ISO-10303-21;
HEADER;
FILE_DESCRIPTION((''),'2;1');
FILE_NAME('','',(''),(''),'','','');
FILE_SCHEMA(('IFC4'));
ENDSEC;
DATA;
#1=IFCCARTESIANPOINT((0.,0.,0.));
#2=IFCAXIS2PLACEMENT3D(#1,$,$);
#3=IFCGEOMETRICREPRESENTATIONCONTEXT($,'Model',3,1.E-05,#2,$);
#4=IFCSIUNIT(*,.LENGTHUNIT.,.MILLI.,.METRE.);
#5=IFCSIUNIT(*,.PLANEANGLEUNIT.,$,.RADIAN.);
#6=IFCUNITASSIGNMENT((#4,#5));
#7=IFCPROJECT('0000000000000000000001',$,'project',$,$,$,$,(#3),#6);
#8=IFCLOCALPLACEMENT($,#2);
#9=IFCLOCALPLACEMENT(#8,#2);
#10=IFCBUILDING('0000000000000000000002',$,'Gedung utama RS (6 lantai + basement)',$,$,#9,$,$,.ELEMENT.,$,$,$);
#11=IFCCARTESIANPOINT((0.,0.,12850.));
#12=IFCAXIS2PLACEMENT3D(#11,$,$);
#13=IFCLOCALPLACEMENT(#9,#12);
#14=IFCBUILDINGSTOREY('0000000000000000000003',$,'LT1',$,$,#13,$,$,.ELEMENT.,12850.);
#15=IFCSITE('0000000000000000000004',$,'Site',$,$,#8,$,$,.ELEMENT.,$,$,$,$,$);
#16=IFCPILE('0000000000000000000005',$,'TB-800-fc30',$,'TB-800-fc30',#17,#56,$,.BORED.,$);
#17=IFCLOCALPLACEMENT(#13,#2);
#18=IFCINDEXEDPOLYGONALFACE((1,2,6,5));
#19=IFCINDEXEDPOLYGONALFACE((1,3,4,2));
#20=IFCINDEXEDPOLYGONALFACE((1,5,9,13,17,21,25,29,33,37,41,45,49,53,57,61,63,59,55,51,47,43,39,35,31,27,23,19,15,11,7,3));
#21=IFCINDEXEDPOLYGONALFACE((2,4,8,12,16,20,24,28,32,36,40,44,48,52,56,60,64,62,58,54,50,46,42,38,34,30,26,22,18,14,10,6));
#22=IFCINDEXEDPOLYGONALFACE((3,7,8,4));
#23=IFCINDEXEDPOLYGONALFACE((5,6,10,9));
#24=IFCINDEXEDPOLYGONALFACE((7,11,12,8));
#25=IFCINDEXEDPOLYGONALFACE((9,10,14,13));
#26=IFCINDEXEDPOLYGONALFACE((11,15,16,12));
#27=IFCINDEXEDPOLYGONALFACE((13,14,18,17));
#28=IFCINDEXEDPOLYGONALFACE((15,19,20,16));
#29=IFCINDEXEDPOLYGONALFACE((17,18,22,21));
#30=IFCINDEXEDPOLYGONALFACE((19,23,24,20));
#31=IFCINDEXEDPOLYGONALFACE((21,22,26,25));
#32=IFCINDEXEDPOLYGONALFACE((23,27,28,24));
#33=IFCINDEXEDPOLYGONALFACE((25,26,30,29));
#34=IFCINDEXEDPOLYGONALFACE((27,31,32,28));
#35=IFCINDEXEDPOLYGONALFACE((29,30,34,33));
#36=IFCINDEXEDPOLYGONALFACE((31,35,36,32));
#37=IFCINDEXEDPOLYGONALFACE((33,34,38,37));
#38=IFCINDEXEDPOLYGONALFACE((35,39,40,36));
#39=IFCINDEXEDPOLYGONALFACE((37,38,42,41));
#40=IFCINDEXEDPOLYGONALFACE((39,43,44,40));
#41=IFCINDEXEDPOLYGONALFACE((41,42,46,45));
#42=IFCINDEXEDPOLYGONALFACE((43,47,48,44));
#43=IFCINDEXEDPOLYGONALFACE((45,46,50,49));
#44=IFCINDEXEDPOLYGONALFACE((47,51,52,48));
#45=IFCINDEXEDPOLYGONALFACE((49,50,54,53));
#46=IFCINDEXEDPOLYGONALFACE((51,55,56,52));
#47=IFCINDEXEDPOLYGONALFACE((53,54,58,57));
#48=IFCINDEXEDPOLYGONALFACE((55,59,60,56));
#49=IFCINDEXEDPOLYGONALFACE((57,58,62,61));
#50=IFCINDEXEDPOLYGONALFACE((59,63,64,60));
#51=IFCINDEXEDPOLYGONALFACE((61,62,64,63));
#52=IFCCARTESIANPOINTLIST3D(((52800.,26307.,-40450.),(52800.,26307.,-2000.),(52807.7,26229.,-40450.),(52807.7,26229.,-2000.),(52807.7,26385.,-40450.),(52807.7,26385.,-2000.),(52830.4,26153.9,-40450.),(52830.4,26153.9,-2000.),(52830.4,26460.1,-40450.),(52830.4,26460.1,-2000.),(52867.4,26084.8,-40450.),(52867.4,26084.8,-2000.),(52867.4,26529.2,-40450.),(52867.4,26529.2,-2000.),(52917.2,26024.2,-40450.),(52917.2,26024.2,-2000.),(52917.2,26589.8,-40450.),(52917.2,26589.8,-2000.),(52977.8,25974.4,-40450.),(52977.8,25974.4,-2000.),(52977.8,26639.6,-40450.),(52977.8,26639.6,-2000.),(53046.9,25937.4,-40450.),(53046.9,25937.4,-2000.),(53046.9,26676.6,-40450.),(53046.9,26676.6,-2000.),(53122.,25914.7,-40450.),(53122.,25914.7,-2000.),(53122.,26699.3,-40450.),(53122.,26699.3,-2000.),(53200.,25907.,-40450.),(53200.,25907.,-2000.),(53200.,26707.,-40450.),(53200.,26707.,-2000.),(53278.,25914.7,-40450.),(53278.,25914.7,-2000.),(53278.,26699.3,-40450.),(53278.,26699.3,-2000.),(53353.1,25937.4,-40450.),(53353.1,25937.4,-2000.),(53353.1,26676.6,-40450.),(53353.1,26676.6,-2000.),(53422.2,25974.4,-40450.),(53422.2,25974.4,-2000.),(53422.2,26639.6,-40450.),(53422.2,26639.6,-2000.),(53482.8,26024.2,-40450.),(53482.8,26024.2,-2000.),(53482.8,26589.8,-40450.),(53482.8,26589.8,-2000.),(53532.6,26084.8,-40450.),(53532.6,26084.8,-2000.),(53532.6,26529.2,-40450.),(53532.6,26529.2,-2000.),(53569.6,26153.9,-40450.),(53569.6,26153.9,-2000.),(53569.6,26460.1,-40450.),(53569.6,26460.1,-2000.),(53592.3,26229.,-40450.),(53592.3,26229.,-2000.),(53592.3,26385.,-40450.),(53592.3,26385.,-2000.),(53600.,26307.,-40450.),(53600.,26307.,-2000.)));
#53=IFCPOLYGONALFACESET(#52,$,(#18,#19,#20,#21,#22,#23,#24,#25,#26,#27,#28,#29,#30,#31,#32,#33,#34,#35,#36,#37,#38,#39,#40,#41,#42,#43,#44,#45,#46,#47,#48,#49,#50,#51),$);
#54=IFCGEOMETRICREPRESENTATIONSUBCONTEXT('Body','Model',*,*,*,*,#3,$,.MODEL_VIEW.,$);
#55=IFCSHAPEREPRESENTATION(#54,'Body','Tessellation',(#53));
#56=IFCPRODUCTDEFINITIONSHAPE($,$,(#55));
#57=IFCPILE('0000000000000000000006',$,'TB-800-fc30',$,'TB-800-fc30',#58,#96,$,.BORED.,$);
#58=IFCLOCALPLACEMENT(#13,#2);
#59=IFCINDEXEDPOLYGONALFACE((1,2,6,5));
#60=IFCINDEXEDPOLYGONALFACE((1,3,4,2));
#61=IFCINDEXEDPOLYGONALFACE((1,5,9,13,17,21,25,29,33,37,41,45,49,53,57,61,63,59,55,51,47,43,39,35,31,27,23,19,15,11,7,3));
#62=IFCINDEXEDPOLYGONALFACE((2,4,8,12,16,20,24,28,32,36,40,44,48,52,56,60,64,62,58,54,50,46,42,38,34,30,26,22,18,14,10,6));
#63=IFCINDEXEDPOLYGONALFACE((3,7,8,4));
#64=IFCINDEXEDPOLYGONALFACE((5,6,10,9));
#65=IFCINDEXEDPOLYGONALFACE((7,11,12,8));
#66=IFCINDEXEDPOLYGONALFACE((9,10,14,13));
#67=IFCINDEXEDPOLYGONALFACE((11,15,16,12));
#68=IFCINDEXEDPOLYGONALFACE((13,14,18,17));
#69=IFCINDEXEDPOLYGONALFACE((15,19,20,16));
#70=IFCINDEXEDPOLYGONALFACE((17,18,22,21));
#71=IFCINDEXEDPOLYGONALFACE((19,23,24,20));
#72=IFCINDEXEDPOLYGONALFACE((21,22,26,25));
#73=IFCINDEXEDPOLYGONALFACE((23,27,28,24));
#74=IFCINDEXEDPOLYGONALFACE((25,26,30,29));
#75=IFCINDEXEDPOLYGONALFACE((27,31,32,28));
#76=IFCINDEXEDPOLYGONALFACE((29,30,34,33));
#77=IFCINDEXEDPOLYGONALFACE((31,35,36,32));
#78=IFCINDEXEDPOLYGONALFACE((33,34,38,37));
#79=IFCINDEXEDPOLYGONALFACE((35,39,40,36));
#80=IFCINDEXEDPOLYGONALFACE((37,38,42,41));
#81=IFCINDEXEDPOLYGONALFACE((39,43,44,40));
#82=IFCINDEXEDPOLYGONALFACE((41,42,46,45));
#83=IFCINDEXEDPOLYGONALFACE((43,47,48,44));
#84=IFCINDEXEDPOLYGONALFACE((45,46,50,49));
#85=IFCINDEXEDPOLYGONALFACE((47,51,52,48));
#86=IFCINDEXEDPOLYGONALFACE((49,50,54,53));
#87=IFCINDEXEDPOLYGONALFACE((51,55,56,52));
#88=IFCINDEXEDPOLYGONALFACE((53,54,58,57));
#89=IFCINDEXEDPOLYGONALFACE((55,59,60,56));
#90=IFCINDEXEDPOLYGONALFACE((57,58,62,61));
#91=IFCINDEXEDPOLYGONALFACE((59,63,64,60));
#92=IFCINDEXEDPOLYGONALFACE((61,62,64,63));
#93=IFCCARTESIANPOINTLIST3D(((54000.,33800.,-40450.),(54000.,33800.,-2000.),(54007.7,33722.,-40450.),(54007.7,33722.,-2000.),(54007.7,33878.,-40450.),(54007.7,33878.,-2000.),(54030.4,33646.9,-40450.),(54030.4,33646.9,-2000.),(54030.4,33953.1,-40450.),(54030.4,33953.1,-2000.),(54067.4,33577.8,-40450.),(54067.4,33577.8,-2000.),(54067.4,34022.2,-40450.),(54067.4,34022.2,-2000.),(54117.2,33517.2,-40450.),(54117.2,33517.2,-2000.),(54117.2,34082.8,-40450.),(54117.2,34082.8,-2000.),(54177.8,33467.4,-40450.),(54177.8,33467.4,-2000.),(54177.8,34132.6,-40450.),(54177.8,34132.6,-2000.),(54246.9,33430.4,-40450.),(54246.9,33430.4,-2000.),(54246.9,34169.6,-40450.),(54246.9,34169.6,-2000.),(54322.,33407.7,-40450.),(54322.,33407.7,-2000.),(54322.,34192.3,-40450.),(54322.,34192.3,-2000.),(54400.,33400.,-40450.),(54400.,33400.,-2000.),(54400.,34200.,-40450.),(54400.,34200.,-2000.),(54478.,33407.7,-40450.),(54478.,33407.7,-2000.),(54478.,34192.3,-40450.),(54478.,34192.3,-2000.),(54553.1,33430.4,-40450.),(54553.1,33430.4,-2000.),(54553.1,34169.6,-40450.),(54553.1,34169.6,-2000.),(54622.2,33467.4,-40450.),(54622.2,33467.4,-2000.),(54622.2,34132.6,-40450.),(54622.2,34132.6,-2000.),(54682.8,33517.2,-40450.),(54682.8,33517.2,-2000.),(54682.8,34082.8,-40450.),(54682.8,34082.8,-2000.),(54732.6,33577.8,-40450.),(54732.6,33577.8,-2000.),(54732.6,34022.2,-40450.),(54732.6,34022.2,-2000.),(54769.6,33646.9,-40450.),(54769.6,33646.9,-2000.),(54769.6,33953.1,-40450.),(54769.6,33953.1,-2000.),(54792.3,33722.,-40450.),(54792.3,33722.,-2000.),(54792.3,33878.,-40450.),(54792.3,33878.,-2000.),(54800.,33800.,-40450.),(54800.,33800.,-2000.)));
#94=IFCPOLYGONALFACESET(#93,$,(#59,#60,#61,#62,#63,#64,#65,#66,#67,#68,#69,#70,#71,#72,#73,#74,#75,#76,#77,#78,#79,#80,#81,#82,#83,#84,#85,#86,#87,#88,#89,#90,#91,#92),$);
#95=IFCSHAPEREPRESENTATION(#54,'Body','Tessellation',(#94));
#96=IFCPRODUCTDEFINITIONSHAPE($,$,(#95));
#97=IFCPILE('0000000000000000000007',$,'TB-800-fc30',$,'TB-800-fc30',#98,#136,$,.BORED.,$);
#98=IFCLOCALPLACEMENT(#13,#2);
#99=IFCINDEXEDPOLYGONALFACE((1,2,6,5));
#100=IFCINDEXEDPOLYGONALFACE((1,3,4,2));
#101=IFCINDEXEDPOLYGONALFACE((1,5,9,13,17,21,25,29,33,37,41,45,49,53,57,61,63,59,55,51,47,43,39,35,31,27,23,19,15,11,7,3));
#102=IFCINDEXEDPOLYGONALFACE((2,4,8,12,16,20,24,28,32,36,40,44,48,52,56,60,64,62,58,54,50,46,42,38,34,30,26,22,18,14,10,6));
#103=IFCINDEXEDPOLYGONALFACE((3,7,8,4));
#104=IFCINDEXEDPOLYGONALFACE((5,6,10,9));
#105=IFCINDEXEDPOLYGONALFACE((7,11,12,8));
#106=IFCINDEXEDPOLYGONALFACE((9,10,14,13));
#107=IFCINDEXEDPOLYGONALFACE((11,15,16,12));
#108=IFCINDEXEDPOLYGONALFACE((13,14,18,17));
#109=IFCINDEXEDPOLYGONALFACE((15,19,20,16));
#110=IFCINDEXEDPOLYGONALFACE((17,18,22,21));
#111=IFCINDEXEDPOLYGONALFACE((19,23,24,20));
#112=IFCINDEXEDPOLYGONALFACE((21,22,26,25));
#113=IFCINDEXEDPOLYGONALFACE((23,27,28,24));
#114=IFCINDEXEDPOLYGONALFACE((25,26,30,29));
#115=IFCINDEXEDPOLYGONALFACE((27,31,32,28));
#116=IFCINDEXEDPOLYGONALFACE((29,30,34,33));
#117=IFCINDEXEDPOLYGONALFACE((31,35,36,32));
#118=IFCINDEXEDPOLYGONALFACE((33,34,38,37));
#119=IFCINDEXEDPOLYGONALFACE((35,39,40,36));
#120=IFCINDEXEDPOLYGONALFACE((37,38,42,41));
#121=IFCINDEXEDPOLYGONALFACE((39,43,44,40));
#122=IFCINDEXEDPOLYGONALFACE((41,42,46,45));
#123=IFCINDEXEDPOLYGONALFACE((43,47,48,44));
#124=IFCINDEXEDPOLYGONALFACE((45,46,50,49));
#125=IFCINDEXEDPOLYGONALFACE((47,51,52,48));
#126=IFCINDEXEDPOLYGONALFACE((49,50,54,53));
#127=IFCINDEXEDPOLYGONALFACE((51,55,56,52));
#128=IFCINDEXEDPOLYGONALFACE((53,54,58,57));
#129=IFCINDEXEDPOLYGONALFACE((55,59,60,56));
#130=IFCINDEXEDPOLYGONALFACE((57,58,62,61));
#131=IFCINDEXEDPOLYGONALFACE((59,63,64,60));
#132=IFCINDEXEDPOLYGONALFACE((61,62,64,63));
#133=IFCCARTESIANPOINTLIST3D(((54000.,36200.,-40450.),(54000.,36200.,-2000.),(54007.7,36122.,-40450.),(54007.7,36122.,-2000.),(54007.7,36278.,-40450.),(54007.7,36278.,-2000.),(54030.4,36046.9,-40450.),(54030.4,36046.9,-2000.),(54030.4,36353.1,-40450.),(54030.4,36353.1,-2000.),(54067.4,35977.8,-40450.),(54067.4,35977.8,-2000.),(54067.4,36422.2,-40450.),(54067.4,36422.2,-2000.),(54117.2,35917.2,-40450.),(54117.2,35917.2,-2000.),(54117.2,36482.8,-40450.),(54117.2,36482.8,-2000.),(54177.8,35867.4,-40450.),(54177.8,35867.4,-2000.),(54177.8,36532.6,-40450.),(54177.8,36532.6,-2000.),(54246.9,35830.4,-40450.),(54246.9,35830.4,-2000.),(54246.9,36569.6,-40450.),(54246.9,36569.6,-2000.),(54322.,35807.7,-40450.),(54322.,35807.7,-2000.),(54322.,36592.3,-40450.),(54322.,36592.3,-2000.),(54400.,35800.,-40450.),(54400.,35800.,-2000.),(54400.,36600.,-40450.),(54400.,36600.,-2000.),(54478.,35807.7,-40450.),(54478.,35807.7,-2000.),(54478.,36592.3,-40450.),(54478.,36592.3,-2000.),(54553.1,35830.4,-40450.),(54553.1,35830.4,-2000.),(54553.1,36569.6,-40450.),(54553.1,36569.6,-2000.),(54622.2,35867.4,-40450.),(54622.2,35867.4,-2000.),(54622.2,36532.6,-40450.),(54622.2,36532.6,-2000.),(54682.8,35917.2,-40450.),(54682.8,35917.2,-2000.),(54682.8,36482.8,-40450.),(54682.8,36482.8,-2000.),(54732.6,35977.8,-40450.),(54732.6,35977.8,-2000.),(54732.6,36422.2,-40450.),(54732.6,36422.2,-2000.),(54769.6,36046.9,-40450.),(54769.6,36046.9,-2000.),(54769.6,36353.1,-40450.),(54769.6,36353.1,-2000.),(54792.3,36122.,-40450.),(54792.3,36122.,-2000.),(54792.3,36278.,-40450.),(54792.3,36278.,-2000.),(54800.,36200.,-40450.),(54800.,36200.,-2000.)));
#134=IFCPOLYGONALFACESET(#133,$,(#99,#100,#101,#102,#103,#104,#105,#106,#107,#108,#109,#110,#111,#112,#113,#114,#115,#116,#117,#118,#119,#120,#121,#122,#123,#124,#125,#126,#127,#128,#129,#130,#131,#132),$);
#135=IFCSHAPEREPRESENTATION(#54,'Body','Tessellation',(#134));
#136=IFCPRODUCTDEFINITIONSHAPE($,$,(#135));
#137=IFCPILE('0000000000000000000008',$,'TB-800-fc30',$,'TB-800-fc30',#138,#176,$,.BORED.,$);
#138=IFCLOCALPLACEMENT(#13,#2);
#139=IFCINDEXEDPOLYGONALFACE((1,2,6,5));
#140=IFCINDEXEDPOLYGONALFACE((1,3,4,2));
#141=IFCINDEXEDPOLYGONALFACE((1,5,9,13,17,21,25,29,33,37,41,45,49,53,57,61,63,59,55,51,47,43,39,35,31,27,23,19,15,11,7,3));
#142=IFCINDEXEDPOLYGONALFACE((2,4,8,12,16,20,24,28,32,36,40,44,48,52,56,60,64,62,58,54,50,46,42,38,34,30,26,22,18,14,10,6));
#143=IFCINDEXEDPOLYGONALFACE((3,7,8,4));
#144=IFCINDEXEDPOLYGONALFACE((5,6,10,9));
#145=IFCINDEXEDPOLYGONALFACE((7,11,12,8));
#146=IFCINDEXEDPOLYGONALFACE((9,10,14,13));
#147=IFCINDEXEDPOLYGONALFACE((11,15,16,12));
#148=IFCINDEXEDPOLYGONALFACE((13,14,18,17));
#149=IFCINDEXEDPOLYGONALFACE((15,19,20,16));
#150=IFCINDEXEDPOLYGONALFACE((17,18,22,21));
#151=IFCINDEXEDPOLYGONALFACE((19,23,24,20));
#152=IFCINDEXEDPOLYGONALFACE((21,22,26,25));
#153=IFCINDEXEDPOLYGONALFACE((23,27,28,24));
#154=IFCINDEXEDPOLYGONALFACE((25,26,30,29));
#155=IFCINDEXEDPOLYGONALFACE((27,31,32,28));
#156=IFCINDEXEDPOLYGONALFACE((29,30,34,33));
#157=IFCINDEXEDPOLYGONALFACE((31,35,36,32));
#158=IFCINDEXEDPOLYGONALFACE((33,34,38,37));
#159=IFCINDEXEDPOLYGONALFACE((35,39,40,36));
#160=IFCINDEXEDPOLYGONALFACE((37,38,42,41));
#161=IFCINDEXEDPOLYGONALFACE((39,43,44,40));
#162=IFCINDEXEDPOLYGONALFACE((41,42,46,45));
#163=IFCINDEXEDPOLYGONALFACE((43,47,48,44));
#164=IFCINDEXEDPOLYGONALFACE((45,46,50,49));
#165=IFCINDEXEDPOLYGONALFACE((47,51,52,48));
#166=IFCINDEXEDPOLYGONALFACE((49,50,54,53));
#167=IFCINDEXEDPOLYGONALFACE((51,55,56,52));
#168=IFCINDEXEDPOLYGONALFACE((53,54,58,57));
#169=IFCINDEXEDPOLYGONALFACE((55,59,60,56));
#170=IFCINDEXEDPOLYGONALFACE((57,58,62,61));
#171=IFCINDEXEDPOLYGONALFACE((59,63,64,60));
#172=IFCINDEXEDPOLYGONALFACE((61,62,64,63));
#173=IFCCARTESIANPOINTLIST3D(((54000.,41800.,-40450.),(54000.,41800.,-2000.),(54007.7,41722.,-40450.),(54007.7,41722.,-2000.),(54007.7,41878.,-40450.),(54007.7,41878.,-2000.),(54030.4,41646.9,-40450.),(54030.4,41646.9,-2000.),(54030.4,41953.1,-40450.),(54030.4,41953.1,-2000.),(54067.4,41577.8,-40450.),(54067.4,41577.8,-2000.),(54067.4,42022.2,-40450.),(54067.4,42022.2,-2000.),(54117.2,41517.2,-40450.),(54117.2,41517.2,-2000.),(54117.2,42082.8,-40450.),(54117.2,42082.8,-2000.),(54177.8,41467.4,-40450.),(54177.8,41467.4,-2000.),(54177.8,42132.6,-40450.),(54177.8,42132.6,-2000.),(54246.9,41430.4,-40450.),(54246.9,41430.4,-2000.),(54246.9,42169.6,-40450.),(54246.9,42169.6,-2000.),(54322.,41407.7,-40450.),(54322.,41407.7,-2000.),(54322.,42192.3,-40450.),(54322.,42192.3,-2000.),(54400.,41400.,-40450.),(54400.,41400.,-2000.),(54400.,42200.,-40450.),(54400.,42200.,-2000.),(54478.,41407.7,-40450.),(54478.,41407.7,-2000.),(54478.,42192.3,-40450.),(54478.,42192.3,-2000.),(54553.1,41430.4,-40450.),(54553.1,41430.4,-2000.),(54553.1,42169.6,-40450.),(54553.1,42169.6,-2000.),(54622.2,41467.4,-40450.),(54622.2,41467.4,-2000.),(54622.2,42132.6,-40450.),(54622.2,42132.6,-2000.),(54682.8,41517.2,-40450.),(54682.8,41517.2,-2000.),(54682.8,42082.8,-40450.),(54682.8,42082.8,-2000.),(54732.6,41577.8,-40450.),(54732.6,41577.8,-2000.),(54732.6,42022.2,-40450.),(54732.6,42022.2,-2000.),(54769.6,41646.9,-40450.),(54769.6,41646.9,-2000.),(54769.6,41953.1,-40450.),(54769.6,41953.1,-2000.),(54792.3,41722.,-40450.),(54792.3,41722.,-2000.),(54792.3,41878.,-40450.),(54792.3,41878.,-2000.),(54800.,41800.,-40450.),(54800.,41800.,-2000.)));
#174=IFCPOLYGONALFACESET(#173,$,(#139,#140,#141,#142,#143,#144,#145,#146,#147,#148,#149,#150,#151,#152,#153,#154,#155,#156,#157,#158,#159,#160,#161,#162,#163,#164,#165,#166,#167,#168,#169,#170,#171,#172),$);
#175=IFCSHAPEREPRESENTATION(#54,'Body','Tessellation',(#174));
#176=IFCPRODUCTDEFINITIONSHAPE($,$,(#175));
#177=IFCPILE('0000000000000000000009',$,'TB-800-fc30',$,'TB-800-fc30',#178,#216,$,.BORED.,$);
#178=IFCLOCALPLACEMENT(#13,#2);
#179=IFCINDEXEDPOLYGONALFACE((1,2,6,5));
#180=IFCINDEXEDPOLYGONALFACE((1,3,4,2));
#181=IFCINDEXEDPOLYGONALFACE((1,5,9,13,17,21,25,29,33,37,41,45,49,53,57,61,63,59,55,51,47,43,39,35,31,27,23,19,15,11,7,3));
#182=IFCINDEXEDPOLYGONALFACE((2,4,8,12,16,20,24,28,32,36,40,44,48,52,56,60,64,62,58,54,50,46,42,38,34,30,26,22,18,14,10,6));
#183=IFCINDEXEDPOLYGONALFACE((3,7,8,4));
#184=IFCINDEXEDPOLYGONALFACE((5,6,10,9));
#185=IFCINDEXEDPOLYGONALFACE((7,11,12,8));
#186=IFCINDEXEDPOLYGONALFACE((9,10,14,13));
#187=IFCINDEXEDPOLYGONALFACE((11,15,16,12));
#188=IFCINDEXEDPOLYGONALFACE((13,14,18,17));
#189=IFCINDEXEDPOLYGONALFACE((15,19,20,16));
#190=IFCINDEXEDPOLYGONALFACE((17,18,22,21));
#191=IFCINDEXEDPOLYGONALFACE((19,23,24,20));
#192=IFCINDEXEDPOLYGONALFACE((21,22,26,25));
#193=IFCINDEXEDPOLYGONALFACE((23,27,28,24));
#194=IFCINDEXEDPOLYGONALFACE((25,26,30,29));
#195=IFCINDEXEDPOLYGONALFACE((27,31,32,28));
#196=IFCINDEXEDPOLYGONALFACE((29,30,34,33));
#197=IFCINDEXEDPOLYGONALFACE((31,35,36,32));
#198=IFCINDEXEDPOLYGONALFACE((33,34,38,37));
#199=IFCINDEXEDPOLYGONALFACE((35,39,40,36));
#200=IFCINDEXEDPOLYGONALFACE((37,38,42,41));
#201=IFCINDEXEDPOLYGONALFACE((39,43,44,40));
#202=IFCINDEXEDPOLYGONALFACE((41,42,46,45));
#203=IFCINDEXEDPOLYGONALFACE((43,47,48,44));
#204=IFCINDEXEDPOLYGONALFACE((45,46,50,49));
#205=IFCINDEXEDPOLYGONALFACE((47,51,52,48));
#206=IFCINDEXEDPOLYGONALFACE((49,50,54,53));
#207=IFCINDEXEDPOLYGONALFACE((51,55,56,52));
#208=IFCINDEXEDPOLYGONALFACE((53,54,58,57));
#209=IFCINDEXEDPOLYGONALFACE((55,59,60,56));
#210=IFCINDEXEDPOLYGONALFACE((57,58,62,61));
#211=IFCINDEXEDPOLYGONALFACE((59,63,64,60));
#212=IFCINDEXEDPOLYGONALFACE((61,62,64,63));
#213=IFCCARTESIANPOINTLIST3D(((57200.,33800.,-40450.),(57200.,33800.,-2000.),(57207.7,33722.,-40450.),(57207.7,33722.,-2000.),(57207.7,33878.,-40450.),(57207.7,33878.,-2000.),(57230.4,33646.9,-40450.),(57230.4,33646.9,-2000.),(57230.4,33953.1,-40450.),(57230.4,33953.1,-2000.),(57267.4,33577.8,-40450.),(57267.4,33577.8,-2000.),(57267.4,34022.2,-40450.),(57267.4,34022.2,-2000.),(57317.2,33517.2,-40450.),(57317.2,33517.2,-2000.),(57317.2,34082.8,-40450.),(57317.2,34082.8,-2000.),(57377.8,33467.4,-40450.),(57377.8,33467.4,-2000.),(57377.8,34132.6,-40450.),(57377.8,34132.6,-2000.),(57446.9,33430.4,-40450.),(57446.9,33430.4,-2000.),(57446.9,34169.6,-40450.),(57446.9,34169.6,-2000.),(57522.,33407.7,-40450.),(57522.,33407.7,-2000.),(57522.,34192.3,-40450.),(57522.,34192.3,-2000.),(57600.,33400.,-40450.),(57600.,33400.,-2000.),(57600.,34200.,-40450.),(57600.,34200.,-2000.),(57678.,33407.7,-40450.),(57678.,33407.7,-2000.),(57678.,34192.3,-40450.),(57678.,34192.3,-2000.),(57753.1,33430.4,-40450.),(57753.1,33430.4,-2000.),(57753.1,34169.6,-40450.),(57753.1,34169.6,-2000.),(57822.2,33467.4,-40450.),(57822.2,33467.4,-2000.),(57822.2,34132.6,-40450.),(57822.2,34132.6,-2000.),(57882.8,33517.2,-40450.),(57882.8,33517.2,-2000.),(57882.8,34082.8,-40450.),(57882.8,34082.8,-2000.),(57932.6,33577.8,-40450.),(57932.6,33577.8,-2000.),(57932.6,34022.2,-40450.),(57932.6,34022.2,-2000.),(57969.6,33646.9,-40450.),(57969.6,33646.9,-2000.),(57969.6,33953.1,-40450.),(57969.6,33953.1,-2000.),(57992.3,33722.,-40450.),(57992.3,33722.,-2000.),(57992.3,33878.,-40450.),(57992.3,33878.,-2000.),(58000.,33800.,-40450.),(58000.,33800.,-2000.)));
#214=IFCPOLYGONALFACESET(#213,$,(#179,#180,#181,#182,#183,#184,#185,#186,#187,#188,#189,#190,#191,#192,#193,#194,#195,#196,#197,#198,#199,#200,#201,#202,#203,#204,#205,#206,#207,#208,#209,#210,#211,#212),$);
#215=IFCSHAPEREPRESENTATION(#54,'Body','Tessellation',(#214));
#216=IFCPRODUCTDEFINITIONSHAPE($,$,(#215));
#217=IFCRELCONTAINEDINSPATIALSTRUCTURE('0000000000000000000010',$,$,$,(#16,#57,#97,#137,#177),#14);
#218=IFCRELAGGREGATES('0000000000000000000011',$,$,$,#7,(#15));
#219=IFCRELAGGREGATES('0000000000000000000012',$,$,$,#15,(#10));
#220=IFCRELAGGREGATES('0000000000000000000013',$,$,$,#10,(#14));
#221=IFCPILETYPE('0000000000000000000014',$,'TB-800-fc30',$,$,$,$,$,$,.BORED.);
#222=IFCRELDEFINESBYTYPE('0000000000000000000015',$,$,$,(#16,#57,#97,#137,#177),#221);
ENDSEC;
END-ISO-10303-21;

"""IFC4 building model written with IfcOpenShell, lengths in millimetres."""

from ifc_helpers import new_model, si_unit, frame, origin, origin_2d, place, context, subcontext, project, spatial, circle, extrude, material_profile, profile_set, profile_usage, type_object, element, save


model = new_model("IFC4")

# Units and contexts
model_context = context("Model", 3, precision=1e-05, world=origin())
body_context = subcontext(model_context, "Body", "Model", "MODEL_VIEW")
ifc_project = project(units=[si_unit("LENGTHUNIT", "METRE", prefix="MILLI"), si_unit("PLANEANGLEUNIT", "RADIAN")], contexts=[model_context])

# Site, building, storey
site_placement = place(None, origin())
site = spatial("IfcSite", under=ifc_project, at=site_placement, Name="Site", CompositionType="ELEMENT")
building_placement = place(site_placement, origin())
building = spatial("IfcBuilding", under=site, at=building_placement, Name="Gedung utama RS (6 lantai + basement)", CompositionType="ELEMENT")
storey_placement = place(building_placement, frame((0.0, 0.0, 12850.0)))
storey = spatial("IfcBuildingStorey", under=building, at=storey_placement, Name="LT1", CompositionType="ELEMENT", Elevation=12850.0)

# Piles
ifc_material_profile_1 = material_profile(None, circle(Radius=400.0, at=origin_2d()), Name="TB-800-fc30")
ifc_profile_set_1 = profile_set([ifc_material_profile_1], Name="TB-800-fc30")
ifc_profile_usage_1 = profile_usage(ifc_profile_set_1, cardinal=5)
pile_type = type_object("IfcPileType", Name="TB-800-fc30", PredefinedType="BORED", material=ifc_profile_set_1)
for number, where, z_axis, x_axis, name in (
    (1, (53200.0, 26307.0, -40450.0), (0.0, 0.0, 1.0), (1.0, 0.0, 0.0), "TB-800-fc30"),
    (2, (54400.0, 33800.0, -40450.0), (0.0, 0.0, 1.0), (1.0, 0.0, 0.0), "TB-800-fc30"),
    (3, (54400.0, 36200.0, -40450.0), (0.0, 0.0, 1.0), (1.0, 0.0, 0.0), "TB-800-fc30"),
    (4, (54400.0, 41800.0, -40450.0), (0.0, 0.0, 1.0), (1.0, 0.0, 0.0), "TB-800-fc30"),
    (5, (57600.0, 33800.0, -40450.0), (0.0, 0.0, 1.0), (1.0, 0.0, 0.0), "TB-800-fc30"),
):
    element("IfcPile", number, at=place(storey_placement, frame(where, z_axis=z_axis, x_axis=x_axis)), inside=storey, type_object=pile_type, material=ifc_profile_usage_1, Name=name, ObjectType="TB-800-fc30", PredefinedType="BORED", context=body_context, shape_type="SweptSolid", body=[
        extrude(circle(Radius=400.0, at=origin_2d()), origin(), (0.0, 0.0, 1.0), 38450.0),
    ])

save(model, "model.ifc")
